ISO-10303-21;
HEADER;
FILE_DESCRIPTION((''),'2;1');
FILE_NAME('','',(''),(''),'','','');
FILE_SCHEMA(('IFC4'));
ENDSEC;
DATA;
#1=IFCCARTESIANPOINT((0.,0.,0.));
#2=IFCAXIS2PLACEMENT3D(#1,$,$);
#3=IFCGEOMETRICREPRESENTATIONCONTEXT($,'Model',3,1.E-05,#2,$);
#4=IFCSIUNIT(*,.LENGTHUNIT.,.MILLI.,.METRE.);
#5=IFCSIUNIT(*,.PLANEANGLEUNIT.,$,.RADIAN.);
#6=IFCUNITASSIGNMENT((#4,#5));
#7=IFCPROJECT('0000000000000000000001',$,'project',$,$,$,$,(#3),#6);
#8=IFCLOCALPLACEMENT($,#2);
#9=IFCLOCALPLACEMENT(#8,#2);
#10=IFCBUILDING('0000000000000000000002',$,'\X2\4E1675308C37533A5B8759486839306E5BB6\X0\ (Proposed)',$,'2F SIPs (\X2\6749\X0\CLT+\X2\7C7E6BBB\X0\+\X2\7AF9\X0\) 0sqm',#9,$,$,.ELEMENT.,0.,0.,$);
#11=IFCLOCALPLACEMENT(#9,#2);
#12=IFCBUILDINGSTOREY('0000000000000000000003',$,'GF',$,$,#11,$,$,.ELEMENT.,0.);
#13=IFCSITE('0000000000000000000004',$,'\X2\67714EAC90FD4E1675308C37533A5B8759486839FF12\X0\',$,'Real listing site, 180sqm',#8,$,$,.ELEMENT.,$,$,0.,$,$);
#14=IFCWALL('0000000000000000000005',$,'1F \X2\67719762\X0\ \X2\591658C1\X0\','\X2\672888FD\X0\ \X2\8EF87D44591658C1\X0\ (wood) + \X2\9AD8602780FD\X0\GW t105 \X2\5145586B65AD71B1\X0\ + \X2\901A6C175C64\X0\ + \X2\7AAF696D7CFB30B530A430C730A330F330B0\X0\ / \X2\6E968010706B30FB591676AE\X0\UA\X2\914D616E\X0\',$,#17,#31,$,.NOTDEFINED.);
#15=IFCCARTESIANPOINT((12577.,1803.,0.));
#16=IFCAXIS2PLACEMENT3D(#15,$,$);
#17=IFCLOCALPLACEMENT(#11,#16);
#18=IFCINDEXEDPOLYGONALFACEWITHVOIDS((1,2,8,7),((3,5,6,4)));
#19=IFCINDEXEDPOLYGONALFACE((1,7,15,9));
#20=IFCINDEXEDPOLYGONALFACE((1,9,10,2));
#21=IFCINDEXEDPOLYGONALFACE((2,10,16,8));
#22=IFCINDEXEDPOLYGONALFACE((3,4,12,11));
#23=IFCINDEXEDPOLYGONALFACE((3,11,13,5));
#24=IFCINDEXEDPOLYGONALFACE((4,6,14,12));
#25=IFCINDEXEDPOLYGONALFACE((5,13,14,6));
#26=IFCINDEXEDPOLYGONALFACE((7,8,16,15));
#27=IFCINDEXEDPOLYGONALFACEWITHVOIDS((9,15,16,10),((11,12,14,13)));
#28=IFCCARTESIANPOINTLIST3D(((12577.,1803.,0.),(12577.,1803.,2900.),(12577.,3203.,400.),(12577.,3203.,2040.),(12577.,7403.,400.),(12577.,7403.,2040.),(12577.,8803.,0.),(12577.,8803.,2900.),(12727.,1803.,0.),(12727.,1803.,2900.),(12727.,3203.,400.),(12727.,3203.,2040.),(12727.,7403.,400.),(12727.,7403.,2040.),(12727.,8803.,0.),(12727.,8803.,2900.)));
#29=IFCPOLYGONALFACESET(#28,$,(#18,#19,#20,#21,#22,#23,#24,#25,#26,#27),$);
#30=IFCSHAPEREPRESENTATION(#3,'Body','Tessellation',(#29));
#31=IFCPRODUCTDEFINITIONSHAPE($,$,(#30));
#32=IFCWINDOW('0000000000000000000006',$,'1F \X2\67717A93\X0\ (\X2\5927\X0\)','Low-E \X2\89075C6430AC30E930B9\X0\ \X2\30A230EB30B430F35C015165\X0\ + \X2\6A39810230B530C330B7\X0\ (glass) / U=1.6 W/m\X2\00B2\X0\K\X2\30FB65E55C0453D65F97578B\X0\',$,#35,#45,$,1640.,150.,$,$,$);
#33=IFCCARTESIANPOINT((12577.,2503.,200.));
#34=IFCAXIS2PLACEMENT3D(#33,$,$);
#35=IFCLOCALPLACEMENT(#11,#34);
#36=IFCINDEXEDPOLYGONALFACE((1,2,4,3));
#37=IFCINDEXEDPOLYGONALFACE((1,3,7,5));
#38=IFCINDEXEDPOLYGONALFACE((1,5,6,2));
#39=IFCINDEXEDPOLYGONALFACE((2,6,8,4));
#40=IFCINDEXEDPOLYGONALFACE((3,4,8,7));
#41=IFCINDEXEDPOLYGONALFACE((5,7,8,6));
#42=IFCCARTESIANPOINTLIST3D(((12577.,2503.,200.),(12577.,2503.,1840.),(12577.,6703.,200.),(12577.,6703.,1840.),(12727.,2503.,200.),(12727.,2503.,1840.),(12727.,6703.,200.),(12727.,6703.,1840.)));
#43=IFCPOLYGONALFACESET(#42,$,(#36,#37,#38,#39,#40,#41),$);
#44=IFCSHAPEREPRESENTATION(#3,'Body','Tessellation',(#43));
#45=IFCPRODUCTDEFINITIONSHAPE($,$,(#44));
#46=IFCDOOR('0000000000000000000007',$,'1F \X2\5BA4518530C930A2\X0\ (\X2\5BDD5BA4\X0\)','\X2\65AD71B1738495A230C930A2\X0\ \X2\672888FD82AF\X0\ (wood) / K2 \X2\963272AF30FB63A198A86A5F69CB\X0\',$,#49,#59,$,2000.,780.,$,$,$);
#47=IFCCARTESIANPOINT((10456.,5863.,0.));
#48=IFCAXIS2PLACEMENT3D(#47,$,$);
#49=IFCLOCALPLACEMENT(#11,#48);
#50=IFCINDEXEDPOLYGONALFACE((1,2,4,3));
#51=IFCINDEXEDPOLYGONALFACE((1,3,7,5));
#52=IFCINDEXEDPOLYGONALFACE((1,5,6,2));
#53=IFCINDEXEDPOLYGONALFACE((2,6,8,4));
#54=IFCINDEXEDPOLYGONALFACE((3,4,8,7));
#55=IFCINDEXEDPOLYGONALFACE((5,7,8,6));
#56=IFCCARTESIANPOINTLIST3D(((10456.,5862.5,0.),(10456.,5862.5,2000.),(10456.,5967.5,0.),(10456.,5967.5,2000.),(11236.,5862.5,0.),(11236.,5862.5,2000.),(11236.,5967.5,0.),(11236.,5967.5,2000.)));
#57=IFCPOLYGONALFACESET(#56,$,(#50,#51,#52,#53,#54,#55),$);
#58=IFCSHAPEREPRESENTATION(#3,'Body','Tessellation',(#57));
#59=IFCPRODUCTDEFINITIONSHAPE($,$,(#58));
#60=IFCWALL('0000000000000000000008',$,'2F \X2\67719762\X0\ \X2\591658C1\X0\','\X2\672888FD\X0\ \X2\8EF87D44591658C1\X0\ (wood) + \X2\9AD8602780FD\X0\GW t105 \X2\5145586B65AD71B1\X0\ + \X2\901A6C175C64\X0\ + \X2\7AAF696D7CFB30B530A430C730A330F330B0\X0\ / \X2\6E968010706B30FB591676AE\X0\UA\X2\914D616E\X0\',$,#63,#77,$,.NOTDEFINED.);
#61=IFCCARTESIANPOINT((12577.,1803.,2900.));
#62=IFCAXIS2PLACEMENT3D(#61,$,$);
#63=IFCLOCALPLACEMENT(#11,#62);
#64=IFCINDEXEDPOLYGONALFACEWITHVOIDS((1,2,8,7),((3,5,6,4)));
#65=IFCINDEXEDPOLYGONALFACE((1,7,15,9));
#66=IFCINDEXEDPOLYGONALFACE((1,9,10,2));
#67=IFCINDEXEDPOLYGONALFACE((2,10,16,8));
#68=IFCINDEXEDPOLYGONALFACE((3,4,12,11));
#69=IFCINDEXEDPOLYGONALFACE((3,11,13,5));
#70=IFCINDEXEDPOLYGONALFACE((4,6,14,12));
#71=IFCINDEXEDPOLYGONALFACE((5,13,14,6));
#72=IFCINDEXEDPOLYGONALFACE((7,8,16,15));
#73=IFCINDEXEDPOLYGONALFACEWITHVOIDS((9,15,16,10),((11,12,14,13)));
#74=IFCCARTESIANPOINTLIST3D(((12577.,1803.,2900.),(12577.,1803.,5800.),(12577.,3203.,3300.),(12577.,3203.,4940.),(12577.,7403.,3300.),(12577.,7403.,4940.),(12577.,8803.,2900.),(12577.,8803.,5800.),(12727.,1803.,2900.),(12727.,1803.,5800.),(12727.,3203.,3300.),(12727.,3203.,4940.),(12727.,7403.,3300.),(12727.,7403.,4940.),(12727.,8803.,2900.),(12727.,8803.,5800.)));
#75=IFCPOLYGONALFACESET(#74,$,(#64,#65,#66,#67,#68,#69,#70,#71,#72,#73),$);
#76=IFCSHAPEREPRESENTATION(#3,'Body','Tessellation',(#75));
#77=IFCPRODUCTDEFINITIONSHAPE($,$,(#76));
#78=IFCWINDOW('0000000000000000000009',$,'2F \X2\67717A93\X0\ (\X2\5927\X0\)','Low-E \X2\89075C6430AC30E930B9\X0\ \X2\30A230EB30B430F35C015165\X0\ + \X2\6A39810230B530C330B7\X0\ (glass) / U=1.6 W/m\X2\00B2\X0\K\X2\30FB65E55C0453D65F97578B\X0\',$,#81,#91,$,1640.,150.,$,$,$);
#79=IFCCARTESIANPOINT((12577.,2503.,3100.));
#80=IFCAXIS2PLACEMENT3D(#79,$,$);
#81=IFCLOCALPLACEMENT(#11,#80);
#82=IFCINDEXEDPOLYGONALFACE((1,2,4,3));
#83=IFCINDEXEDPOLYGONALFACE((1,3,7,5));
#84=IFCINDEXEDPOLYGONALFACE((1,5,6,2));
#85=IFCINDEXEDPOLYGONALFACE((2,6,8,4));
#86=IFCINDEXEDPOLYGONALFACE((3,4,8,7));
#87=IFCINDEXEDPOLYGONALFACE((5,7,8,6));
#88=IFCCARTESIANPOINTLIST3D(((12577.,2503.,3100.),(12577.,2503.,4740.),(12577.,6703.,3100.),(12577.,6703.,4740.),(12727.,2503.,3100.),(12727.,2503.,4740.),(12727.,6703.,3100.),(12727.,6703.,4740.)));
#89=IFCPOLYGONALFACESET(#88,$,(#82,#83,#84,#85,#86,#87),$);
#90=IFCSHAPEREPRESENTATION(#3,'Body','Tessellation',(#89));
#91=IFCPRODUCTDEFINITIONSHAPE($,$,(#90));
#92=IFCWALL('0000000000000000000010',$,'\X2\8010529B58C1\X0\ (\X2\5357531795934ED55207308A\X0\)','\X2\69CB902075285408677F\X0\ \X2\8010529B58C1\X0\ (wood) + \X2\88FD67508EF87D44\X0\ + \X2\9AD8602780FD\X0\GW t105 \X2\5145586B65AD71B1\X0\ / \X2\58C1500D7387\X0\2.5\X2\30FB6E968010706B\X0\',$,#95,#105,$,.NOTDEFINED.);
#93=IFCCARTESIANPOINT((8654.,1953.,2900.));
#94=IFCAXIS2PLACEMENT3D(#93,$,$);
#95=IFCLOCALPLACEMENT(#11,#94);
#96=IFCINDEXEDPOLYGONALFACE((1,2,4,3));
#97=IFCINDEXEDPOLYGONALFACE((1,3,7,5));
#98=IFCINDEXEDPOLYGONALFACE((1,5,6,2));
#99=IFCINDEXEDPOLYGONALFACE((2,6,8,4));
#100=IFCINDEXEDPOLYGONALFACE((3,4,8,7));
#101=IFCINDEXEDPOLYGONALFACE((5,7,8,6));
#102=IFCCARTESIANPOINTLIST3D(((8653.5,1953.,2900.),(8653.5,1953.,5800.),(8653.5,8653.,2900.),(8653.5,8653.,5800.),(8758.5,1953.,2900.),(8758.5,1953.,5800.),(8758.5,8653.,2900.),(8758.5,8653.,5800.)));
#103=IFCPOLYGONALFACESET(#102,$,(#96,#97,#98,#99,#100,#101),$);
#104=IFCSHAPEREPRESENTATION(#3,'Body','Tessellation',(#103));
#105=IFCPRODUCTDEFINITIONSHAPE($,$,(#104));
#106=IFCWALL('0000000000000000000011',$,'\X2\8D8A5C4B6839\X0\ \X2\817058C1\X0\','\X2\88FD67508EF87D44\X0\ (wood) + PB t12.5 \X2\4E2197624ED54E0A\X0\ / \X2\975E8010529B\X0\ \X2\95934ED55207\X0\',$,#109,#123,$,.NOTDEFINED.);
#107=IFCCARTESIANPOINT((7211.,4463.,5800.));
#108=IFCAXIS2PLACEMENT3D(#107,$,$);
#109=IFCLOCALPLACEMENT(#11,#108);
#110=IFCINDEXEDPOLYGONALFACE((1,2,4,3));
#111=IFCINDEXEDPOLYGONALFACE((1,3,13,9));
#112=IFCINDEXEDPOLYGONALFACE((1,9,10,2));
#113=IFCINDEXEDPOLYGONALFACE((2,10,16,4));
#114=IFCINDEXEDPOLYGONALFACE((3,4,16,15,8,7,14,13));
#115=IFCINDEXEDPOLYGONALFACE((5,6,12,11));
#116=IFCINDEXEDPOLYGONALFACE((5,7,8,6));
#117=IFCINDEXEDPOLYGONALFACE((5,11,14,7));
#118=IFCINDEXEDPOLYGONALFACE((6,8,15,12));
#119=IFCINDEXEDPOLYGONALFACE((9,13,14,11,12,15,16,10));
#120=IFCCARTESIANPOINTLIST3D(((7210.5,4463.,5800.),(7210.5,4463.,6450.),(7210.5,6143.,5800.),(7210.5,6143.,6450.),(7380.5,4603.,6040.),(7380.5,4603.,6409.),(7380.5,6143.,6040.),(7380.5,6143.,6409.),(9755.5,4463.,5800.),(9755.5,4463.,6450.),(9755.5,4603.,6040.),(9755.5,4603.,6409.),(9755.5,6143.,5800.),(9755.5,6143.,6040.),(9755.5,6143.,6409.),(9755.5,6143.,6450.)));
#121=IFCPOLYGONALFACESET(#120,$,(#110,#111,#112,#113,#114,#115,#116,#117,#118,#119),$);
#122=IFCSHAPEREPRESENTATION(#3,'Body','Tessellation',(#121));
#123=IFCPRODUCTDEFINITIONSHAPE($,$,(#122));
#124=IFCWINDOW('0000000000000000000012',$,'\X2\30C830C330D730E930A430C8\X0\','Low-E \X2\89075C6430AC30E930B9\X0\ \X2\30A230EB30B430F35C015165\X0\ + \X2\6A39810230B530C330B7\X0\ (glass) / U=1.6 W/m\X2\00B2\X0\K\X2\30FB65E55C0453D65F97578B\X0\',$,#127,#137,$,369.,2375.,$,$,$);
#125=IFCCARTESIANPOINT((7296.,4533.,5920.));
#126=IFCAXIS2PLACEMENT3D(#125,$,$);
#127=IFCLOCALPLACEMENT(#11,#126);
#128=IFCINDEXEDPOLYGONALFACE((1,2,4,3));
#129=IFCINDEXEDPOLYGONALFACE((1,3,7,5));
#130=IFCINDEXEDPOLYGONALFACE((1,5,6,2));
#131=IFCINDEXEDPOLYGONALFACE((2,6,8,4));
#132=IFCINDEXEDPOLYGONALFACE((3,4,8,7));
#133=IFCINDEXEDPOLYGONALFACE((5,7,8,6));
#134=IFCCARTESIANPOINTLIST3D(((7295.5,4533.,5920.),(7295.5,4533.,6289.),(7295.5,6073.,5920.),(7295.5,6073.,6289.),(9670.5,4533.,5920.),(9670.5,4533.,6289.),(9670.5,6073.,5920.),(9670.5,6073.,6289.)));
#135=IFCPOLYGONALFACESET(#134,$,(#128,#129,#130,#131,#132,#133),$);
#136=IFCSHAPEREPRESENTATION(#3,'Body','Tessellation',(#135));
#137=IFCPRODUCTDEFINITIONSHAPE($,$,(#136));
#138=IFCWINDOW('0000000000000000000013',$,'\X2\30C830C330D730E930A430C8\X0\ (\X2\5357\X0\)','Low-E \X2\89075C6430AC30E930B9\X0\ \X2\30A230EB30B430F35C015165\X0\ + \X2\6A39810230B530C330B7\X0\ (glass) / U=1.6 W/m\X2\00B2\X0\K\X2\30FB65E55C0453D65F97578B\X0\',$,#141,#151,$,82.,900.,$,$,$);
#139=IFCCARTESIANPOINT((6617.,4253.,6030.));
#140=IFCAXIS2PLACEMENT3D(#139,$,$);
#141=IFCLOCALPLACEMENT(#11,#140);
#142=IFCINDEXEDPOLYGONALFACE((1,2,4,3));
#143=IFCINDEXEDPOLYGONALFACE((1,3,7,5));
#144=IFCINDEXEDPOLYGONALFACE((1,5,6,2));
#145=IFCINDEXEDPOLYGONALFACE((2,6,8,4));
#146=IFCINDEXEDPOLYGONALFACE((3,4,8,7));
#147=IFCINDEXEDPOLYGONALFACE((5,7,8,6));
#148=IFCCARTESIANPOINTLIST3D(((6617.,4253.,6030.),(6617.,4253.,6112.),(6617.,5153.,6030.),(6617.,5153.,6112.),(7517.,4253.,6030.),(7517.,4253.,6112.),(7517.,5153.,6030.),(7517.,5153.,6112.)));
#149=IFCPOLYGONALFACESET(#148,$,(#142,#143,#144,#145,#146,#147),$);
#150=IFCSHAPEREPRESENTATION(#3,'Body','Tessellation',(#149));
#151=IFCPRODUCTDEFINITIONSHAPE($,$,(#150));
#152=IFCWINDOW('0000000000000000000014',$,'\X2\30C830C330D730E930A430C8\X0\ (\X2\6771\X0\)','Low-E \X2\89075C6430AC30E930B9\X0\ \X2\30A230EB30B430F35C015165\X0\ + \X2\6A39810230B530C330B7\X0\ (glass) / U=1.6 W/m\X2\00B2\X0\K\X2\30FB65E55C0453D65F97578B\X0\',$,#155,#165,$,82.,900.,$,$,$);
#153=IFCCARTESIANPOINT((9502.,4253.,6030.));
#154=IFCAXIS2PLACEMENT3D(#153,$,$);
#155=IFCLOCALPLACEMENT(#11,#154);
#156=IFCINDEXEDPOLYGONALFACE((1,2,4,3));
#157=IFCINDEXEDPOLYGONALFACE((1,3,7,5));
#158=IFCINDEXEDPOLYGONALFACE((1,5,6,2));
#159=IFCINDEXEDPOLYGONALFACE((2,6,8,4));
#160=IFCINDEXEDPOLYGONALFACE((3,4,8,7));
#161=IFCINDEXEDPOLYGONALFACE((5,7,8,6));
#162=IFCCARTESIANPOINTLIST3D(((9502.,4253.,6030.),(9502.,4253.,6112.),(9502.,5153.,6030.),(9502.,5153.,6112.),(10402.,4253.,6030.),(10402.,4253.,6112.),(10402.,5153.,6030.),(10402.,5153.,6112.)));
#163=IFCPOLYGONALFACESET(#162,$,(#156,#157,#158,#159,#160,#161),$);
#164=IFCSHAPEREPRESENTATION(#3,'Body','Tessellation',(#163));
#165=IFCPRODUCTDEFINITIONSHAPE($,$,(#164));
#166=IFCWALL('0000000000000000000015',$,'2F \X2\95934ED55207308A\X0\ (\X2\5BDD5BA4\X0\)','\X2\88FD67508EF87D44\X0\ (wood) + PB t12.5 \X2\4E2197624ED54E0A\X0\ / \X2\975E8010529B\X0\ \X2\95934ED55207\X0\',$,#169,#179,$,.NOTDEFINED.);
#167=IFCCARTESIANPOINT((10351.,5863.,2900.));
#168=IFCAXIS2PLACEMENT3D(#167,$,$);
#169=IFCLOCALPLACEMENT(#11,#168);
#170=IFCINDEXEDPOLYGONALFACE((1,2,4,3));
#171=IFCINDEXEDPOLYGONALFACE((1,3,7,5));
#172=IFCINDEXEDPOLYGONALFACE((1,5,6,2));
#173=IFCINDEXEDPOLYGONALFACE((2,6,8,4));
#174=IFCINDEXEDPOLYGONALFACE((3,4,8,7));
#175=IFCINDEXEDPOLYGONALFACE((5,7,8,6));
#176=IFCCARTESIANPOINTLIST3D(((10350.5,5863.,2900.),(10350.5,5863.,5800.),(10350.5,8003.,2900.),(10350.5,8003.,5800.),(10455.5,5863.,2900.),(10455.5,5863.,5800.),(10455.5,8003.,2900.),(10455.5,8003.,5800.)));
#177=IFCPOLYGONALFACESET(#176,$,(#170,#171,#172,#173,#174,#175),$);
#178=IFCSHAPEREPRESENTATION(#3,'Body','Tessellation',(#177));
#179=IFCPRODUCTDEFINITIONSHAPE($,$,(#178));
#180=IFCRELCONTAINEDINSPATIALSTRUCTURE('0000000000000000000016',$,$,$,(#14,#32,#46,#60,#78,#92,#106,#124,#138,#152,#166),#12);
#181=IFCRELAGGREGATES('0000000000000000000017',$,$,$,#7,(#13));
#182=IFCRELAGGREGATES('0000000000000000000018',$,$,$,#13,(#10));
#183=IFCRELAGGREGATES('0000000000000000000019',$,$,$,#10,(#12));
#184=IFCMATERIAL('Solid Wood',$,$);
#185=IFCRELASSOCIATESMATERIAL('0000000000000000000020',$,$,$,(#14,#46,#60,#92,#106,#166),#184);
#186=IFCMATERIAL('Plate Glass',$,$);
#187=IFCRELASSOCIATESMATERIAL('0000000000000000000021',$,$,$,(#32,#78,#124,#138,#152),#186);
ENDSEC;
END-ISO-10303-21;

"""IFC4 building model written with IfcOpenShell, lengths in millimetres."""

from ifc_helpers import new_model, si_unit, frame, frame_2d, origin, place, context, project, spatial, rectangle, extrude, material, element, fill, save


model = new_model("IFC4")

# Units and contexts
model_context = context("Model", 3, precision=1e-05, world=origin())
ifc_project = project(units=[si_unit("LENGTHUNIT", "METRE", prefix="MILLI"), si_unit("PLANEANGLEUNIT", "RADIAN")], contexts=[model_context])

# Site, building, storey
site_placement = place(None, origin())
site = spatial("IfcSite", under=ifc_project, at=site_placement, Name="東京都世田谷区宇奈根２", ObjectType="Real listing site, 180sqm", CompositionType="ELEMENT", RefElevation=0.0)
building_placement = place(site_placement, origin())
building = spatial("IfcBuilding", under=site, at=building_placement, Name="世田谷区宇奈根の家 (Proposed)", ObjectType="2F SIPs (杉CLT+籾殻+竹) 0sqm", CompositionType="ELEMENT", ElevationOfRefHeight=0.0, ElevationOfTerrain=0.0)
storey_placement = place(building_placement, origin())
storey = spatial("IfcBuildingStorey", under=building, at=storey_placement, Name="GF", CompositionType="ELEMENT", Elevation=0.0)

# Wall, opening, window
ifc_material_1 = material(Name="Solid Wood")
wall_1_placement = place(storey_placement, frame((12577.0, 1803.0, 0.0)))
wall_1 = element("IfcWall", 1, at=wall_1_placement, inside=storey, material=ifc_material_1, Name="1F 東面 外壁", Description="木製 軸組外壁 (wood) + 高性能GW t105 充填断熱 + 通気層 + 窯業系サイディング / 準耐火・外皮UA配慮", PredefinedType="NOTDEFINED", context=model_context, shape_type="SweptSolid", body=[
    extrude(rectangle(XDim=150.0, YDim=7000.0, at=frame_2d((75.0, 3500.0))), frame((12577.0, 1803.0, 0.0)), (0.0, 0.0, 1.0), 2900.0),
])
opening_1_placement = place(storey_placement, frame((12577.0, 2503.0, 200.0)))
opening_1 = element("IfcOpeningElement", 2, at=opening_1_placement, cuts=wall_1, PredefinedType="NOTDEFINED", context=model_context, shape_type="SweptSolid", body=[
    extrude(rectangle(XDim=150.0, YDim=4200.0, at=frame_2d((75.0, 2100.0))), frame((12577.0, 2503.0, 200.0)), (0.0, 0.0, 1.0), 1640.0),
])
ifc_material_2 = material(Name="Plate Glass")
window_1_placement = place(storey_placement, frame((12577.0, 2503.0, 200.0)))
window_1 = element("IfcWindow", 3, at=window_1_placement, inside=storey, material=ifc_material_2, Name="1F 東窓 (大)", Description="Low-E 複層ガラス アルゴン封入 + 樹脂サッシ (glass) / U=1.6 W/m²K・日射取得型", OverallHeight=1640.0, OverallWidth=150.0, context=model_context, shape_type="SweptSolid", body=[
    extrude(rectangle(XDim=150.0, YDim=4200.0, at=frame_2d((75.0, 2100.0))), frame((12577.0, 2503.0, 200.0)), (0.0, 0.0, 1.0), 1640.0),
])
fill(opening_1, window_1)

# Door
door_1_placement = place(storey_placement, frame((10456.0, 5863.0, 0.0)))
element("IfcDoor", 4, at=door_1_placement, inside=storey, material=ifc_material_1, Name="1F 室内ドア (寝室)", Description="断熱玄関ドア 木製芯 (wood) / K2 防犯・採風機構", OverallHeight=2000.0, OverallWidth=780.0, context=model_context, shape_type="SweptSolid", body=[
    extrude(rectangle(XDim=780.0, YDim=105.0, at=frame_2d((390.0, 52.0))), frame((10456.0, 5863.0, 0.0)), (0.0, 0.0, 1.0), 2000.0),
])

# Wall, opening, window
wall_2_placement = place(storey_placement, frame((12577.0, 1803.0, 2900.0)))
wall_2 = element("IfcWall", 5, at=wall_2_placement, inside=storey, material=ifc_material_1, Name="2F 東面 外壁", Description="木製 軸組外壁 (wood) + 高性能GW t105 充填断熱 + 通気層 + 窯業系サイディング / 準耐火・外皮UA配慮", PredefinedType="NOTDEFINED", context=model_context, shape_type="SweptSolid", body=[
    extrude(rectangle(XDim=150.0, YDim=7000.0, at=frame_2d((75.0, 3500.0))), frame((12577.0, 1803.0, 2900.0)), (0.0, 0.0, 1.0), 2900.0),
])
opening_2_placement = place(storey_placement, frame((12577.0, 2503.0, 3100.0)))
opening_2 = element("IfcOpeningElement", 6, at=opening_2_placement, cuts=wall_2, PredefinedType="NOTDEFINED", context=model_context, shape_type="SweptSolid", body=[
    extrude(rectangle(XDim=150.0, YDim=4200.0, at=frame_2d((75.0, 2100.0))), frame((12577.0, 2503.0, 3100.0)), (0.0, 0.0, 1.0), 1640.0),
])
window_2_placement = place(storey_placement, frame((12577.0, 2503.0, 3100.0)))
window_2 = element("IfcWindow", 7, at=window_2_placement, inside=storey, material=ifc_material_2, Name="2F 東窓 (大)", Description="Low-E 複層ガラス アルゴン封入 + 樹脂サッシ (glass) / U=1.6 W/m²K・日射取得型", OverallHeight=1640.0, OverallWidth=150.0, context=model_context, shape_type="SweptSolid", body=[
    extrude(rectangle(XDim=150.0, YDim=4200.0, at=frame_2d((75.0, 2100.0))), frame((12577.0, 2503.0, 3100.0)), (0.0, 0.0, 1.0), 1640.0),
])
fill(opening_2, window_2)

# Wall
wall_3_placement = place(storey_placement, frame((8654.0, 1953.0, 2900.0)))
element("IfcWall", 8, at=wall_3_placement, inside=storey, material=ifc_material_1, Name="耐力壁 (南北間仕切り)", Description="構造用合板 耐力壁 (wood) + 製材軸組 + 高性能GW t105 充填断熱 / 壁倍率2.5・準耐火", PredefinedType="NOTDEFINED", context=model_context, shape_type="SweptSolid", body=[
    extrude(rectangle(XDim=105.0, YDim=6700.0, at=frame_2d((52.0, 3350.0))), frame((8654.0, 1953.0, 2900.0)), (0.0, 0.0, 1.0), 2900.0),
])

# Wall, openings, windows
wall_4_placement = place(storey_placement, frame((7211.0, 4463.0, 5800.0)))
wall_4 = element("IfcWall", 9, at=wall_4_placement, inside=storey, material=ifc_material_1, Name="越屋根 腰壁", Description="製材軸組 (wood) + PB t12.5 両面仕上 / 非耐力 間仕切", PredefinedType="NOTDEFINED", context=model_context, shape_type="SweptSolid", body=[
    extrude(rectangle(XDim=2545.0, YDim=1680.0, at=frame_2d((1272.0, 840.0))), frame((7211.0, 4463.0, 5800.0)), (0.0, 0.0, 1.0), 650.0),
])
opening_3_placement = place(storey_placement, frame((7296.0, 4533.0, 5920.0)))
opening_3 = element("IfcOpeningElement", 10, at=opening_3_placement, cuts=wall_4, PredefinedType="NOTDEFINED", context=model_context, shape_type="SweptSolid", body=[
    extrude(rectangle(XDim=2375.0, YDim=1540.0, at=frame_2d((1187.0, 770.0))), frame((7296.0, 4533.0, 5920.0)), (0.0, 0.0, 1.0), 369.0),
])
opening_4_placement = place(storey_placement, frame((6617.0, 4253.0, 6030.0)))
opening_4 = element("IfcOpeningElement", 11, at=opening_4_placement, cuts=wall_4, PredefinedType="NOTDEFINED", context=model_context, shape_type="SweptSolid", body=[
    extrude(rectangle(XDim=900.0, YDim=900.0, at=frame_2d((450.0, 450.0))), frame((6617.0, 4253.0, 6030.0)), (0.0, 0.0, 1.0), 82.0),
])
opening_5_placement = place(storey_placement, frame((9502.0, 4253.0, 6030.0)))
opening_5 = element("IfcOpeningElement", 12, at=opening_5_placement, cuts=wall_4, PredefinedType="NOTDEFINED", context=model_context, shape_type="SweptSolid", body=[
    extrude(rectangle(XDim=900.0, YDim=900.0, at=frame_2d((450.0, 450.0))), frame((9502.0, 4253.0, 6030.0)), (0.0, 0.0, 1.0), 82.0),
])
window_3_placement = place(storey_placement, frame((7296.0, 4533.0, 5920.0)))
window_3 = element("IfcWindow", 13, at=window_3_placement, inside=storey, material=ifc_material_2, Name="トップライト", Description="Low-E 複層ガラス アルゴン封入 + 樹脂サッシ (glass) / U=1.6 W/m²K・日射取得型", OverallHeight=369.0, OverallWidth=2375.0, context=model_context, shape_type="SweptSolid", body=[
    extrude(rectangle(XDim=2375.0, YDim=1540.0, at=frame_2d((1187.0, 770.0))), frame((7296.0, 4533.0, 5920.0)), (0.0, 0.0, 1.0), 369.0),
])
fill(opening_3, window_3)
window_4_placement = place(storey_placement, frame((6617.0, 4253.0, 6030.0)))
window_4 = element("IfcWindow", 14, at=window_4_placement, inside=storey, material=ifc_material_2, Name="トップライト (南)", Description="Low-E 複層ガラス アルゴン封入 + 樹脂サッシ (glass) / U=1.6 W/m²K・日射取得型", OverallHeight=82.0, OverallWidth=900.0, context=model_context, shape_type="SweptSolid", body=[
    extrude(rectangle(XDim=900.0, YDim=900.0, at=frame_2d((450.0, 450.0))), frame((6617.0, 4253.0, 6030.0)), (0.0, 0.0, 1.0), 82.0),
])
fill(opening_4, window_4)
window_5_placement = place(storey_placement, frame((9502.0, 4253.0, 6030.0)))
window_5 = element("IfcWindow", 15, at=window_5_placement, inside=storey, material=ifc_material_2, Name="トップライト (東)", Description="Low-E 複層ガラス アルゴン封入 + 樹脂サッシ (glass) / U=1.6 W/m²K・日射取得型", OverallHeight=82.0, OverallWidth=900.0, context=model_context, shape_type="SweptSolid", body=[
    extrude(rectangle(XDim=900.0, YDim=900.0, at=frame_2d((450.0, 450.0))), frame((9502.0, 4253.0, 6030.0)), (0.0, 0.0, 1.0), 82.0),
])
fill(opening_5, window_5)

# Wall
wall_5_placement = place(storey_placement, frame((10351.0, 5863.0, 2900.0)))
element("IfcWall", 16, at=wall_5_placement, inside=storey, material=ifc_material_1, Name="2F 間仕切り (寝室)", Description="製材軸組 (wood) + PB t12.5 両面仕上 / 非耐力 間仕切", PredefinedType="NOTDEFINED", context=model_context, shape_type="SweptSolid", body=[
    extrude(rectangle(XDim=105.0, YDim=2140.0, at=frame_2d((52.0, 1070.0))), frame((10351.0, 5863.0, 2900.0)), (0.0, 0.0, 1.0), 2900.0),
])

save(model, "model.ifc")
